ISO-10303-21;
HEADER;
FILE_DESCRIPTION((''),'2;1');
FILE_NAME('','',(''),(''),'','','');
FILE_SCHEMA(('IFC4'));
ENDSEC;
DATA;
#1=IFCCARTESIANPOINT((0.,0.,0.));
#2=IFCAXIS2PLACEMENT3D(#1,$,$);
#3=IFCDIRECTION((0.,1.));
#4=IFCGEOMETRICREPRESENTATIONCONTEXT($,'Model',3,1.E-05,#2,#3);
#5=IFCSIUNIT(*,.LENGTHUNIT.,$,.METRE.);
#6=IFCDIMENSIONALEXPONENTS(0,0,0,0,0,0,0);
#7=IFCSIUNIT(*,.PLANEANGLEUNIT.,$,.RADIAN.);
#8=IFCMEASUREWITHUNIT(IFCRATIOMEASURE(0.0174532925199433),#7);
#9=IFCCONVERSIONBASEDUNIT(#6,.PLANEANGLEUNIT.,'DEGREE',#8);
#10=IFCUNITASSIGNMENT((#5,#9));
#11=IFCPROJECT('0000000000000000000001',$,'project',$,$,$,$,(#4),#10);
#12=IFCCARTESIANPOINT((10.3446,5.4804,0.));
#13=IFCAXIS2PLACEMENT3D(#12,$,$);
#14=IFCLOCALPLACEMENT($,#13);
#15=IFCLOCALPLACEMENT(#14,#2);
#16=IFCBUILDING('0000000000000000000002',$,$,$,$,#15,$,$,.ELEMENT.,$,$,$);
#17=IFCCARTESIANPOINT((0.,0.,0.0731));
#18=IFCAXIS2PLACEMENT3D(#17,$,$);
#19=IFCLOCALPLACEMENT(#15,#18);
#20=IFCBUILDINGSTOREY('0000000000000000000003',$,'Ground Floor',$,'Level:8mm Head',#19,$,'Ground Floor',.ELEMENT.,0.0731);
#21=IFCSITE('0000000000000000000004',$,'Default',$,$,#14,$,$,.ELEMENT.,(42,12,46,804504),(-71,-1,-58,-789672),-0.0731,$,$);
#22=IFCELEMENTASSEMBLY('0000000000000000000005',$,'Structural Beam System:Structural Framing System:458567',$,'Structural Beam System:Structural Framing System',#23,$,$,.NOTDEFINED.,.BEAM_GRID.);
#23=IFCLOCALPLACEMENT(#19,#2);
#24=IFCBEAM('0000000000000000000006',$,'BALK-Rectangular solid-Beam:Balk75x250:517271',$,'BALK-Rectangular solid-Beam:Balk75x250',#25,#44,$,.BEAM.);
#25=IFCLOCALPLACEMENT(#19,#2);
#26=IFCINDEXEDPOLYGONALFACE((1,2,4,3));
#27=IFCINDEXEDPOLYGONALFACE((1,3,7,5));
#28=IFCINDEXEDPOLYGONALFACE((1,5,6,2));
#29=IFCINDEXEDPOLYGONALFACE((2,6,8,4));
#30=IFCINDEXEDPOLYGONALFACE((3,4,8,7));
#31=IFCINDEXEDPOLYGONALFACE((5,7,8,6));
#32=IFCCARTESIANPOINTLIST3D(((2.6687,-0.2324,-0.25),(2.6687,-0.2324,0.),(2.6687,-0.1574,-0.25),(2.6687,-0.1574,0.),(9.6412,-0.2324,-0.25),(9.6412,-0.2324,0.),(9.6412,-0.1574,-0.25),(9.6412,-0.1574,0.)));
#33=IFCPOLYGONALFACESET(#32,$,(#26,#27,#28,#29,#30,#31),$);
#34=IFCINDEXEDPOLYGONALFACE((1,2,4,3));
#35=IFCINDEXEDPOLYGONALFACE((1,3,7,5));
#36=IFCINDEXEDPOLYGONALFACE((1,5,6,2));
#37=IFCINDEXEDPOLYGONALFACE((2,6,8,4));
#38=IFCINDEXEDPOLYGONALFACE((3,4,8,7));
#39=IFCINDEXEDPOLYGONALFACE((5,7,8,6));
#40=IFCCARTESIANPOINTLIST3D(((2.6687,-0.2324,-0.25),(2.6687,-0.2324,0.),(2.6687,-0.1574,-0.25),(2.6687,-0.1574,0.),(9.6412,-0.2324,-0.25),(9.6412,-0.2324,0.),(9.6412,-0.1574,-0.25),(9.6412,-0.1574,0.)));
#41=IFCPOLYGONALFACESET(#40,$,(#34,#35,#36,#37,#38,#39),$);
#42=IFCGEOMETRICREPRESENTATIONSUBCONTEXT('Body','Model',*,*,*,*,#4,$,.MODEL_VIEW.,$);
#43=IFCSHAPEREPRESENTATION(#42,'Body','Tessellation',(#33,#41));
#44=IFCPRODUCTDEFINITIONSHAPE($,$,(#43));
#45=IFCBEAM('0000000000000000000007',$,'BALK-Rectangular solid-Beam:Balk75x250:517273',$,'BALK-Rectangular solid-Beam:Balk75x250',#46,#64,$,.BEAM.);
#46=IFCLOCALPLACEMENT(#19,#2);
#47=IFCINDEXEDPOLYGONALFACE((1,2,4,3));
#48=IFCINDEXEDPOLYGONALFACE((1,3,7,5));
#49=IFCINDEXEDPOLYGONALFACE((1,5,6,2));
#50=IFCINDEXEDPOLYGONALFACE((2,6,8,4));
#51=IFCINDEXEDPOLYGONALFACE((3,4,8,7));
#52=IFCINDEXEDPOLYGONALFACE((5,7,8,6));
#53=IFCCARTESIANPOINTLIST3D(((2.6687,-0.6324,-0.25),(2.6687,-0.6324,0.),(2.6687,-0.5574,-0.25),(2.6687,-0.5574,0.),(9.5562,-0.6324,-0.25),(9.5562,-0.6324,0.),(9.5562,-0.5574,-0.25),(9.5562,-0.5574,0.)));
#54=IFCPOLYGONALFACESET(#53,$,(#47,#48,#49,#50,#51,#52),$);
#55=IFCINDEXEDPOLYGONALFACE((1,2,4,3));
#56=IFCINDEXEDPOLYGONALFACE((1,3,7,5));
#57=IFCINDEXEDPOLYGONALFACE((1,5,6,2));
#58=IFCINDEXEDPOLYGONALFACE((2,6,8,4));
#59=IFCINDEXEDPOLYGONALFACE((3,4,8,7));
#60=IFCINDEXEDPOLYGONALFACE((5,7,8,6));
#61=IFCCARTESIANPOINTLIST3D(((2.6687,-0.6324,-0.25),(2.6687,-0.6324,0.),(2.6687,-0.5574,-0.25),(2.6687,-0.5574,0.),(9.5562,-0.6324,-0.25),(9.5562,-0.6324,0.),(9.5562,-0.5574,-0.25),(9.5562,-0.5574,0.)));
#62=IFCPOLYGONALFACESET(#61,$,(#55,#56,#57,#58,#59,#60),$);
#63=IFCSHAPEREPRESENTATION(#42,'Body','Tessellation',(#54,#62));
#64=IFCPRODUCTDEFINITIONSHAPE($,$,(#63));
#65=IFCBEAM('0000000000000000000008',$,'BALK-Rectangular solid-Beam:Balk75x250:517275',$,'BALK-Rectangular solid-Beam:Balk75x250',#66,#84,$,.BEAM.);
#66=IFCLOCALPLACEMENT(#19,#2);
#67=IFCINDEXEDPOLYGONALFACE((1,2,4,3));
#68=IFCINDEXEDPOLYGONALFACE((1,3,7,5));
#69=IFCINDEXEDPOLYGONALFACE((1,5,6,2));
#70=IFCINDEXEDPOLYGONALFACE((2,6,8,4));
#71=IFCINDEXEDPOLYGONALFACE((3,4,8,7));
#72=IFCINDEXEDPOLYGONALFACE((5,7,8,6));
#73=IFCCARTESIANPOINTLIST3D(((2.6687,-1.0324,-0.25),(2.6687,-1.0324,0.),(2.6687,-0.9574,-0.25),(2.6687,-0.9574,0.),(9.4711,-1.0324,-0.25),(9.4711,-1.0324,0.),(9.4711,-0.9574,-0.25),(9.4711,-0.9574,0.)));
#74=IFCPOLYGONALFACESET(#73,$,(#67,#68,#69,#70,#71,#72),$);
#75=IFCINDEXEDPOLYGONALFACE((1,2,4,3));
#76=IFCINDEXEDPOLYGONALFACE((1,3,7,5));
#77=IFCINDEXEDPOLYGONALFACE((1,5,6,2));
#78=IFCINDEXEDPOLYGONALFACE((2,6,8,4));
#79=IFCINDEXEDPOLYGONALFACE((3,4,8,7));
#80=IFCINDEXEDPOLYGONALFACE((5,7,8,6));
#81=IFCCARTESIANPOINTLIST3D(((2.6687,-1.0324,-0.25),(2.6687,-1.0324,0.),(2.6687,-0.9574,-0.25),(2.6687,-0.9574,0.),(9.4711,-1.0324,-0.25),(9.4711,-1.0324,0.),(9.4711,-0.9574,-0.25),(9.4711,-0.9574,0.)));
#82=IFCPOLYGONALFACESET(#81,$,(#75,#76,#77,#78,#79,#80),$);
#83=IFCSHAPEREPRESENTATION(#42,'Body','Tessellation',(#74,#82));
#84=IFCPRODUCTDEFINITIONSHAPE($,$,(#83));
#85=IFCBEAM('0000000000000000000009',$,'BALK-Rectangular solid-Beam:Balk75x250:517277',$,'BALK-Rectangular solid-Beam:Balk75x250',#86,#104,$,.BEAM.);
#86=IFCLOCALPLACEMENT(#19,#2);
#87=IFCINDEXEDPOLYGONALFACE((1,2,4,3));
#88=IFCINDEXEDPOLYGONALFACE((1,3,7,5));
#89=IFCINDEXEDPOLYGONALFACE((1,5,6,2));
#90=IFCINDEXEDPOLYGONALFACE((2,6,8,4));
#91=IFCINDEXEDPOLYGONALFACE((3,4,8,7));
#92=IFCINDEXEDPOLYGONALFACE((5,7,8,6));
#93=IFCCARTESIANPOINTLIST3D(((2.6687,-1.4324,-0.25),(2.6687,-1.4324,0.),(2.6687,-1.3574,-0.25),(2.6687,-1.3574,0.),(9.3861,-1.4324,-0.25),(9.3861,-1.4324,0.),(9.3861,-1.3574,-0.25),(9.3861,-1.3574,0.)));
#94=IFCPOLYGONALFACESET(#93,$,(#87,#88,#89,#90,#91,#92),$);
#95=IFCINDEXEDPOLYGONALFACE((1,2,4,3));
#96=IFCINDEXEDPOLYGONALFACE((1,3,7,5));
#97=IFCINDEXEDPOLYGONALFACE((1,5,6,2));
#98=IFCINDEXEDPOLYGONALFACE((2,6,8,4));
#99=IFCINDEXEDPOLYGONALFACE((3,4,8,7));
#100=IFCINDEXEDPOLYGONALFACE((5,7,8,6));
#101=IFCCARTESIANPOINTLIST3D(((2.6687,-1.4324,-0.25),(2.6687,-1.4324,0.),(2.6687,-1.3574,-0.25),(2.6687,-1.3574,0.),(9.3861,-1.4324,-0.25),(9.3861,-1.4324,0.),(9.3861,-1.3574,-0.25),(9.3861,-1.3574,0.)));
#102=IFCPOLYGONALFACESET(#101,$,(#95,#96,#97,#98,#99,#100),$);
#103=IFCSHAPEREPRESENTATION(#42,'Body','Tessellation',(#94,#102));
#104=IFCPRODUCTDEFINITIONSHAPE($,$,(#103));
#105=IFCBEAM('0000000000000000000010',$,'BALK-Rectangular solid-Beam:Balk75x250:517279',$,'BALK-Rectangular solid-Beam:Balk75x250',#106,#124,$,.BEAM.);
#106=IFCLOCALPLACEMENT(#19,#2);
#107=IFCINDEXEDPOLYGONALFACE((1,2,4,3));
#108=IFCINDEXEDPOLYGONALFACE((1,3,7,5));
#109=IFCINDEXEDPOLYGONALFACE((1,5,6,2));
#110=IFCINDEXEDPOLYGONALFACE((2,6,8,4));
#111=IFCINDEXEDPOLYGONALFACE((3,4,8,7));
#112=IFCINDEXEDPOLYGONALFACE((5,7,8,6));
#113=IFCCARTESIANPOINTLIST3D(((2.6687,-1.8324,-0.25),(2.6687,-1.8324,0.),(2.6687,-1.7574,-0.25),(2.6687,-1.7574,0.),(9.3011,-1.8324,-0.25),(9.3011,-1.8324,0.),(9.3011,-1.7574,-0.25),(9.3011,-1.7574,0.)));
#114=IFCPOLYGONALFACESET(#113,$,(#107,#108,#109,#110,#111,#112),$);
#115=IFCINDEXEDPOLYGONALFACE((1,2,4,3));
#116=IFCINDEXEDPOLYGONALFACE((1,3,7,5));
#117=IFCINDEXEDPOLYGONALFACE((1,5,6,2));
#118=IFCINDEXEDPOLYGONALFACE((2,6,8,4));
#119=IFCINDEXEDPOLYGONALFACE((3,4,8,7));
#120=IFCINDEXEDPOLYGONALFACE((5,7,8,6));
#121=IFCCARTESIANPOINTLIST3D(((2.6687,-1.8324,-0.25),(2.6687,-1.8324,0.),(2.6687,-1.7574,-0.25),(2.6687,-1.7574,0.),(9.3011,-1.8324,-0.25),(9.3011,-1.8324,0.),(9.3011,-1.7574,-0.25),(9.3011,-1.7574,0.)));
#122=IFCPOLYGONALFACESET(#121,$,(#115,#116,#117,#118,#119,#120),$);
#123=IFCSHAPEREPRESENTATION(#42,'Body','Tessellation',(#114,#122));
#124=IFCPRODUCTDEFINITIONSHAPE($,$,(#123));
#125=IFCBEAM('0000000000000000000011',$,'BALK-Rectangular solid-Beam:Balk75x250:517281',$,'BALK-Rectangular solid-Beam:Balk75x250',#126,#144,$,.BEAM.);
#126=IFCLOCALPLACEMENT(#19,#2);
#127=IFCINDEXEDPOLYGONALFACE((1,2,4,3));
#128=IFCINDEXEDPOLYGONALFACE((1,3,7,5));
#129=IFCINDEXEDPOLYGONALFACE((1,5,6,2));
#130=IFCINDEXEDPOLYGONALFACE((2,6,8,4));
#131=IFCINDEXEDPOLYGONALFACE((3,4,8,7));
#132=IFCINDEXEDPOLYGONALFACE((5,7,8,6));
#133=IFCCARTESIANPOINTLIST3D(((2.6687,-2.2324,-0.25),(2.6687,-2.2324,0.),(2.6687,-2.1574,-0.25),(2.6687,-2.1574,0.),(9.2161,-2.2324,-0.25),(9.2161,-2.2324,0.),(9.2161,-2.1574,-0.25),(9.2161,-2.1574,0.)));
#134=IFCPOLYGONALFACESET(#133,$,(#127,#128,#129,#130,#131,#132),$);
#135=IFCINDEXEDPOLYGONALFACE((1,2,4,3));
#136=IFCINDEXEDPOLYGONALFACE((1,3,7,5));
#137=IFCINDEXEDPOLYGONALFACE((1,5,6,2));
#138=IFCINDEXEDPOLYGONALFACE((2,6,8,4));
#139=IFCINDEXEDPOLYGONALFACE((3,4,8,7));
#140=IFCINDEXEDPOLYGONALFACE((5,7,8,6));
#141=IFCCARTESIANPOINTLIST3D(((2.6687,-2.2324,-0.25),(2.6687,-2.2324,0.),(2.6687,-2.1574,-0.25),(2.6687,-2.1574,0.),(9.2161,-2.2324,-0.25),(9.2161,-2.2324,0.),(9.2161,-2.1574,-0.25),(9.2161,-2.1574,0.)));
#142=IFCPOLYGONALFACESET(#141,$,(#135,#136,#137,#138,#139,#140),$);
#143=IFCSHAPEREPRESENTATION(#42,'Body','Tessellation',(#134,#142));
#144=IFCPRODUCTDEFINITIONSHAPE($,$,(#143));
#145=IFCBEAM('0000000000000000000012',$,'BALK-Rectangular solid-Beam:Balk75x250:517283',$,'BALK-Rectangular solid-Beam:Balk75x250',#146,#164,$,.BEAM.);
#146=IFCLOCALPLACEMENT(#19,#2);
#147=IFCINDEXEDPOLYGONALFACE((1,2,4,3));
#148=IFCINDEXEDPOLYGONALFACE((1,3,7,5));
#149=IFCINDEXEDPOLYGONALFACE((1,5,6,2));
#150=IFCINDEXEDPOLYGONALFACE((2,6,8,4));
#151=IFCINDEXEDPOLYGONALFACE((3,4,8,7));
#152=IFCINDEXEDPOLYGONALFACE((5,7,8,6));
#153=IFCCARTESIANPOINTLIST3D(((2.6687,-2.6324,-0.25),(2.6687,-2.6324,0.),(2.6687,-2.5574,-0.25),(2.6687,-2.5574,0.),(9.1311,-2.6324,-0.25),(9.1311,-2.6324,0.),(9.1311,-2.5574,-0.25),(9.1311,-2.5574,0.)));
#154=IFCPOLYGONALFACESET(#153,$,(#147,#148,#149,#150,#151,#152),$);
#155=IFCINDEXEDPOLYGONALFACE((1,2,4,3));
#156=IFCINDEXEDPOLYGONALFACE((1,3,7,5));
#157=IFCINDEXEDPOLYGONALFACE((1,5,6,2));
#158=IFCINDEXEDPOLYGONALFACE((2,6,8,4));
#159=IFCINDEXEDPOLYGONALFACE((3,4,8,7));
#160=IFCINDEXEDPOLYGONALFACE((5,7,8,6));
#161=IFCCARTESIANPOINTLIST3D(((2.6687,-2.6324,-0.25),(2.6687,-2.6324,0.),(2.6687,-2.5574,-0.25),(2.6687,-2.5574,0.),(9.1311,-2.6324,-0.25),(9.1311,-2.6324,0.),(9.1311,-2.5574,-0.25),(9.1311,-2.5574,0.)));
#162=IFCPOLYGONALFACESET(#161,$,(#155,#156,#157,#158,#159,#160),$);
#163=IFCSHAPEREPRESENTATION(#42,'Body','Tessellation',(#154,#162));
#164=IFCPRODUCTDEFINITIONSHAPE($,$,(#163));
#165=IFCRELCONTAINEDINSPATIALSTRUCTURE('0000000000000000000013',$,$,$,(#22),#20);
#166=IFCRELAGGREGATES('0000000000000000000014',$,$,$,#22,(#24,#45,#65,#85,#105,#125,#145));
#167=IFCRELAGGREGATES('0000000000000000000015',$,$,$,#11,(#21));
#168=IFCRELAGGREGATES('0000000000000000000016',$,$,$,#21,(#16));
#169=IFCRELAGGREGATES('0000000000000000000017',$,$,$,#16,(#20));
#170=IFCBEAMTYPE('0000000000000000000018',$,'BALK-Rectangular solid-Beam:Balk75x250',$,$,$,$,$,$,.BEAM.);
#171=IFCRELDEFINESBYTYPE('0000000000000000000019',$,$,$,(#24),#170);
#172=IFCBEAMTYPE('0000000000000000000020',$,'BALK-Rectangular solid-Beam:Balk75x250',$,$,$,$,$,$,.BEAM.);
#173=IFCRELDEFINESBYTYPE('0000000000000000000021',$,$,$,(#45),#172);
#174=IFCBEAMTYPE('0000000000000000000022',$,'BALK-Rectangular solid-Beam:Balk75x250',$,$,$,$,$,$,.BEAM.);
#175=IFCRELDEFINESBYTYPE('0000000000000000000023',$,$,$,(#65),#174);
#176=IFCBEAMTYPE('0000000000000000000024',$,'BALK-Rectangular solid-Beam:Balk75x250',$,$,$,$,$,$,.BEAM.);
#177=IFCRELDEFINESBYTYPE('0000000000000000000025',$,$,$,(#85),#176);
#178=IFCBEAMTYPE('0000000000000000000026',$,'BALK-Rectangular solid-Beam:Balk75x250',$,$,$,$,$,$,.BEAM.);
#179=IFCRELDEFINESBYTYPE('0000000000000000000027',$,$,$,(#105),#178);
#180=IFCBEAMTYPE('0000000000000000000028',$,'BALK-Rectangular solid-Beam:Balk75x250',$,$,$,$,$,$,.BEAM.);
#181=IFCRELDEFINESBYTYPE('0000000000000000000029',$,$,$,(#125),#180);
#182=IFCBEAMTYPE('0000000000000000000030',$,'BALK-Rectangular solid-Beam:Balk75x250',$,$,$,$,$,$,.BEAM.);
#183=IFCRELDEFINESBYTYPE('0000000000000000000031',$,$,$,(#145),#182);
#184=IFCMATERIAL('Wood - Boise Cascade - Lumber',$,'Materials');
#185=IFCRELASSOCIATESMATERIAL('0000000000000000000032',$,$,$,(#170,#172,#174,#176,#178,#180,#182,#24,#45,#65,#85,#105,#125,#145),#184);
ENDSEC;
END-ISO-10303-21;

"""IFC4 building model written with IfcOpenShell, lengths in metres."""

from ifc_helpers import new_model, entity, si_unit, converted_unit, direction, frame, frame_2d, origin, origin_2d_with_axis, place, context, subcontext, project, spatial, rectangle, extrude, source, transform, mapped, material, material_profile, profile_set, profile_usage, type_object, type_shapes, element, aggregate, save


model = new_model("IFC4")

# Units and contexts
model_context = context("Model", 3, precision=1e-05, world=origin(), true_north=direction((0.0, 1.0)))
body_context = subcontext(model_context, "Body", "Model", "MODEL_VIEW")
ifc_project = project(units=[si_unit("LENGTHUNIT", "METRE"), converted_unit("PLANEANGLEUNIT", "DEGREE", entity("IfcRatioMeasure", 0.0174532925199433), si_unit("PLANEANGLEUNIT", "RADIAN"), dimensions=[0, 0, 0, 0, 0, 0, 0])], contexts=[model_context])

# Site, building, storey
site_placement = place(None, frame((10.3446, 5.4804, 0.0)))
site = spatial("IfcSite", under=ifc_project, at=site_placement, Name="Default", CompositionType="ELEMENT", RefLatitude=(42, 12, 46, 804504), RefLongitude=(-71, -1, -58, -789672), RefElevation=-0.0731)
building_placement = place(site_placement, origin())
building = spatial("IfcBuilding", under=site, at=building_placement, CompositionType="ELEMENT")
storey_placement = place(building_placement, frame((0.0, 0.0, 0.0731)))
storey = spatial("IfcBuildingStorey", under=building, at=storey_placement, Name="Ground Floor", ObjectType="Level:8mm Head", LongName="Ground Floor", CompositionType="ELEMENT", Elevation=0.0731)

# Element assembly, beams
assembly_1_placement = place(storey_placement, origin())
assembly_1 = element("IfcElementAssembly", 1, at=assembly_1_placement, inside=storey, Name="Structural Beam System:Structural Framing System:458567", ObjectType="Structural Beam System:Structural Framing System", AssemblyPlace="NOTDEFINED", PredefinedType="BEAM_GRID")
ifc_material_1 = material(Name="Wood - Boise Cascade - Lumber", Category="Materials")
ifc_material_profile = material_profile(ifc_material_1, rectangle(XDim=0.25, YDim=0.075, at=frame_2d((0.0, 0.0), x_axis=(1.0, 0.0))), Name="Balk75x250")
ifc_profile_set = profile_set([ifc_material_profile], Name="Balk75x250")
ifc_profile_usage_1 = profile_usage(ifc_profile_set, cardinal=8)
beam_type_1 = type_object("IfcBeamType", Name="BALK-Rectangular solid-Beam:Balk75x250", PredefinedType="BEAM", material=ifc_profile_set)
shared_shape_1 = source(origin(), body_context, "Body", "SweptSolid", [
    extrude(rectangle(XDim=0.25, YDim=0.075, at=origin_2d_with_axis()), frame((-3.4433, 0.0, 0.0), z_axis=(1.0, 0.0, 0.0), x_axis=(0.0, 0.0, -1.0)), (0.0, 0.0, 1.0), 6.9725),
    extrude(rectangle(XDim=0.25, YDim=0.075, at=origin_2d_with_axis()), frame((-3.4433, 0.0, 0.0), z_axis=(1.0, 0.0, 0.0), x_axis=(0.0, 0.0, -1.0)), (0.0, 0.0, 1.0), 6.9725),
])
type_shapes(beam_type_1, [shared_shape_1])
beam_1_placement = place(assembly_1_placement, frame((6.112, -0.1949, -0.125)))
beam_1 = element("IfcBeam", 2, at=beam_1_placement, type_object=beam_type_1, material=ifc_profile_usage_1, Name="BALK-Rectangular solid-Beam:Balk75x250:517271", ObjectType="BALK-Rectangular solid-Beam:Balk75x250", PredefinedType="BEAM", context=body_context, shape_type="MappedRepresentation", body=[
    mapped(shared_shape_1, transform((0.0, 0.0, 0.0), scale=1.0)),
])
ifc_profile_usage_2 = profile_usage(ifc_profile_set, cardinal=8)
beam_type_2 = type_object("IfcBeamType", Name="BALK-Rectangular solid-Beam:Balk75x250", PredefinedType="BEAM", material=ifc_profile_set)
shared_shape_2 = source(origin(), body_context, "Body", "SweptSolid", [
    extrude(rectangle(XDim=0.25, YDim=0.075, at=origin_2d_with_axis()), frame((-3.4008, 0.0, 0.0), z_axis=(1.0, 0.0, 0.0), x_axis=(0.0, 0.0, -1.0)), (0.0, 0.0, 1.0), 6.8875),
    extrude(rectangle(XDim=0.25, YDim=0.075, at=origin_2d_with_axis()), frame((-3.4008, 0.0, 0.0), z_axis=(1.0, 0.0, 0.0), x_axis=(0.0, 0.0, -1.0)), (0.0, 0.0, 1.0), 6.8875),
])
type_shapes(beam_type_2, [shared_shape_2])
beam_2_placement = place(assembly_1_placement, frame((6.0695, -0.5949, -0.125)))
beam_2 = element("IfcBeam", 3, at=beam_2_placement, type_object=beam_type_2, material=ifc_profile_usage_2, Name="BALK-Rectangular solid-Beam:Balk75x250:517273", ObjectType="BALK-Rectangular solid-Beam:Balk75x250", PredefinedType="BEAM", context=body_context, shape_type="MappedRepresentation", body=[
    mapped(shared_shape_2, transform((0.0, 0.0, 0.0), scale=1.0)),
])
ifc_profile_usage_3 = profile_usage(ifc_profile_set, cardinal=8)
beam_type_3 = type_object("IfcBeamType", Name="BALK-Rectangular solid-Beam:Balk75x250", PredefinedType="BEAM", material=ifc_profile_set)
shared_shape_3 = source(origin(), body_context, "Body", "SweptSolid", [
    extrude(rectangle(XDim=0.25, YDim=0.075, at=origin_2d_with_axis()), frame((-3.3583, 0.0, 0.0), z_axis=(1.0, 0.0, 0.0), x_axis=(0.0, 0.0, -1.0)), (0.0, 0.0, 1.0), 6.8025),
    extrude(rectangle(XDim=0.25, YDim=0.075, at=origin_2d_with_axis()), frame((-3.3583, 0.0, 0.0), z_axis=(1.0, 0.0, 0.0), x_axis=(0.0, 0.0, -1.0)), (0.0, 0.0, 1.0), 6.8025),
])
type_shapes(beam_type_3, [shared_shape_3])
beam_3_placement = place(assembly_1_placement, frame((6.027, -0.9949, -0.125)))
beam_3 = element("IfcBeam", 4, at=beam_3_placement, type_object=beam_type_3, material=ifc_profile_usage_3, Name="BALK-Rectangular solid-Beam:Balk75x250:517275", ObjectType="BALK-Rectangular solid-Beam:Balk75x250", PredefinedType="BEAM", context=body_context, shape_type="MappedRepresentation", body=[
    mapped(shared_shape_3, transform((0.0, 0.0, 0.0), scale=1.0)),
])
ifc_profile_usage_4 = profile_usage(ifc_profile_set, cardinal=8)
beam_type_4 = type_object("IfcBeamType", Name="BALK-Rectangular solid-Beam:Balk75x250", PredefinedType="BEAM", material=ifc_profile_set)
shared_shape_4 = source(origin(), body_context, "Body", "SweptSolid", [
    extrude(rectangle(XDim=0.25, YDim=0.075, at=origin_2d_with_axis()), frame((-3.3158, 0.0, 0.0), z_axis=(1.0, 0.0, 0.0), x_axis=(0.0, 0.0, -1.0)), (0.0, 0.0, 1.0), 6.7175),
    extrude(rectangle(XDim=0.25, YDim=0.075, at=origin_2d_with_axis()), frame((-3.3158, 0.0, 0.0), z_axis=(1.0, 0.0, 0.0), x_axis=(0.0, 0.0, -1.0)), (0.0, 0.0, 1.0), 6.7175),
])
type_shapes(beam_type_4, [shared_shape_4])
beam_4_placement = place(assembly_1_placement, frame((5.9844, -1.3949, -0.125)))
beam_4 = element("IfcBeam", 5, at=beam_4_placement, type_object=beam_type_4, material=ifc_profile_usage_4, Name="BALK-Rectangular solid-Beam:Balk75x250:517277", ObjectType="BALK-Rectangular solid-Beam:Balk75x250", PredefinedType="BEAM", context=body_context, shape_type="MappedRepresentation", body=[
    mapped(shared_shape_4, transform((0.0, 0.0, 0.0), scale=1.0)),
])
ifc_profile_usage_5 = profile_usage(ifc_profile_set, cardinal=8)
beam_type_5 = type_object("IfcBeamType", Name="BALK-Rectangular solid-Beam:Balk75x250", PredefinedType="BEAM", material=ifc_profile_set)
shared_shape_5 = source(origin(), body_context, "Body", "SweptSolid", [
    extrude(rectangle(XDim=0.25, YDim=0.075, at=origin_2d_with_axis()), frame((-3.2733, 0.0, 0.0), z_axis=(1.0, 0.0, 0.0), x_axis=(0.0, 0.0, -1.0)), (0.0, 0.0, 1.0), 6.6324),
    extrude(rectangle(XDim=0.25, YDim=0.075, at=origin_2d_with_axis()), frame((-3.2733, 0.0, 0.0), z_axis=(1.0, 0.0, 0.0), x_axis=(0.0, 0.0, -1.0)), (0.0, 0.0, 1.0), 6.6324),
])
type_shapes(beam_type_5, [shared_shape_5])
beam_5_placement = place(assembly_1_placement, frame((5.9419, -1.7949, -0.125)))
beam_5 = element("IfcBeam", 6, at=beam_5_placement, type_object=beam_type_5, material=ifc_profile_usage_5, Name="BALK-Rectangular solid-Beam:Balk75x250:517279", ObjectType="BALK-Rectangular solid-Beam:Balk75x250", PredefinedType="BEAM", context=body_context, shape_type="MappedRepresentation", body=[
    mapped(shared_shape_5, transform((0.0, 0.0, 0.0), scale=1.0)),
])
ifc_profile_usage_6 = profile_usage(ifc_profile_set, cardinal=8)
beam_type_6 = type_object("IfcBeamType", Name="BALK-Rectangular solid-Beam:Balk75x250", PredefinedType="BEAM", material=ifc_profile_set)
shared_shape_6 = source(origin(), body_context, "Body", "SweptSolid", [
    extrude(rectangle(XDim=0.25, YDim=0.075, at=origin_2d_with_axis()), frame((-3.2308, 0.0, 0.0), z_axis=(1.0, 0.0, 0.0), x_axis=(0.0, 0.0, -1.0)), (0.0, 0.0, 1.0), 6.5474),
    extrude(rectangle(XDim=0.25, YDim=0.075, at=origin_2d_with_axis()), frame((-3.2308, 0.0, 0.0), z_axis=(1.0, 0.0, 0.0), x_axis=(0.0, 0.0, -1.0)), (0.0, 0.0, 1.0), 6.5474),
])
type_shapes(beam_type_6, [shared_shape_6])
beam_6_placement = place(assembly_1_placement, frame((5.8994, -2.1949, -0.125)))
beam_6 = element("IfcBeam", 7, at=beam_6_placement, type_object=beam_type_6, material=ifc_profile_usage_6, Name="BALK-Rectangular solid-Beam:Balk75x250:517281", ObjectType="BALK-Rectangular solid-Beam:Balk75x250", PredefinedType="BEAM", context=body_context, shape_type="MappedRepresentation", body=[
    mapped(shared_shape_6, transform((0.0, 0.0, 0.0), scale=1.0)),
])
ifc_profile_usage_7 = profile_usage(ifc_profile_set, cardinal=8)
beam_type_7 = type_object("IfcBeamType", Name="BALK-Rectangular solid-Beam:Balk75x250", PredefinedType="BEAM", material=ifc_profile_set)
shared_shape_7 = source(origin(), body_context, "Body", "SweptSolid", [
    extrude(rectangle(XDim=0.25, YDim=0.075, at=origin_2d_with_axis()), frame((-3.1883, 0.0, 0.0), z_axis=(1.0, 0.0, 0.0), x_axis=(0.0, 0.0, -1.0)), (0.0, 0.0, 1.0), 6.4624),
    extrude(rectangle(XDim=0.25, YDim=0.075, at=origin_2d_with_axis()), frame((-3.1883, 0.0, 0.0), z_axis=(1.0, 0.0, 0.0), x_axis=(0.0, 0.0, -1.0)), (0.0, 0.0, 1.0), 6.4624),
])
type_shapes(beam_type_7, [shared_shape_7])
beam_7_placement = place(assembly_1_placement, frame((5.8569, -2.5949, -0.125)))
beam_7 = element("IfcBeam", 8, at=beam_7_placement, type_object=beam_type_7, material=ifc_profile_usage_7, Name="BALK-Rectangular solid-Beam:Balk75x250:517283", ObjectType="BALK-Rectangular solid-Beam:Balk75x250", PredefinedType="BEAM", context=body_context, shape_type="MappedRepresentation", body=[
    mapped(shared_shape_7, transform((0.0, 0.0, 0.0), scale=1.0)),
])
aggregate(assembly_1, [beam_1, beam_2, beam_3, beam_4, beam_5, beam_6, beam_7])

save(model, "model.ifc")
